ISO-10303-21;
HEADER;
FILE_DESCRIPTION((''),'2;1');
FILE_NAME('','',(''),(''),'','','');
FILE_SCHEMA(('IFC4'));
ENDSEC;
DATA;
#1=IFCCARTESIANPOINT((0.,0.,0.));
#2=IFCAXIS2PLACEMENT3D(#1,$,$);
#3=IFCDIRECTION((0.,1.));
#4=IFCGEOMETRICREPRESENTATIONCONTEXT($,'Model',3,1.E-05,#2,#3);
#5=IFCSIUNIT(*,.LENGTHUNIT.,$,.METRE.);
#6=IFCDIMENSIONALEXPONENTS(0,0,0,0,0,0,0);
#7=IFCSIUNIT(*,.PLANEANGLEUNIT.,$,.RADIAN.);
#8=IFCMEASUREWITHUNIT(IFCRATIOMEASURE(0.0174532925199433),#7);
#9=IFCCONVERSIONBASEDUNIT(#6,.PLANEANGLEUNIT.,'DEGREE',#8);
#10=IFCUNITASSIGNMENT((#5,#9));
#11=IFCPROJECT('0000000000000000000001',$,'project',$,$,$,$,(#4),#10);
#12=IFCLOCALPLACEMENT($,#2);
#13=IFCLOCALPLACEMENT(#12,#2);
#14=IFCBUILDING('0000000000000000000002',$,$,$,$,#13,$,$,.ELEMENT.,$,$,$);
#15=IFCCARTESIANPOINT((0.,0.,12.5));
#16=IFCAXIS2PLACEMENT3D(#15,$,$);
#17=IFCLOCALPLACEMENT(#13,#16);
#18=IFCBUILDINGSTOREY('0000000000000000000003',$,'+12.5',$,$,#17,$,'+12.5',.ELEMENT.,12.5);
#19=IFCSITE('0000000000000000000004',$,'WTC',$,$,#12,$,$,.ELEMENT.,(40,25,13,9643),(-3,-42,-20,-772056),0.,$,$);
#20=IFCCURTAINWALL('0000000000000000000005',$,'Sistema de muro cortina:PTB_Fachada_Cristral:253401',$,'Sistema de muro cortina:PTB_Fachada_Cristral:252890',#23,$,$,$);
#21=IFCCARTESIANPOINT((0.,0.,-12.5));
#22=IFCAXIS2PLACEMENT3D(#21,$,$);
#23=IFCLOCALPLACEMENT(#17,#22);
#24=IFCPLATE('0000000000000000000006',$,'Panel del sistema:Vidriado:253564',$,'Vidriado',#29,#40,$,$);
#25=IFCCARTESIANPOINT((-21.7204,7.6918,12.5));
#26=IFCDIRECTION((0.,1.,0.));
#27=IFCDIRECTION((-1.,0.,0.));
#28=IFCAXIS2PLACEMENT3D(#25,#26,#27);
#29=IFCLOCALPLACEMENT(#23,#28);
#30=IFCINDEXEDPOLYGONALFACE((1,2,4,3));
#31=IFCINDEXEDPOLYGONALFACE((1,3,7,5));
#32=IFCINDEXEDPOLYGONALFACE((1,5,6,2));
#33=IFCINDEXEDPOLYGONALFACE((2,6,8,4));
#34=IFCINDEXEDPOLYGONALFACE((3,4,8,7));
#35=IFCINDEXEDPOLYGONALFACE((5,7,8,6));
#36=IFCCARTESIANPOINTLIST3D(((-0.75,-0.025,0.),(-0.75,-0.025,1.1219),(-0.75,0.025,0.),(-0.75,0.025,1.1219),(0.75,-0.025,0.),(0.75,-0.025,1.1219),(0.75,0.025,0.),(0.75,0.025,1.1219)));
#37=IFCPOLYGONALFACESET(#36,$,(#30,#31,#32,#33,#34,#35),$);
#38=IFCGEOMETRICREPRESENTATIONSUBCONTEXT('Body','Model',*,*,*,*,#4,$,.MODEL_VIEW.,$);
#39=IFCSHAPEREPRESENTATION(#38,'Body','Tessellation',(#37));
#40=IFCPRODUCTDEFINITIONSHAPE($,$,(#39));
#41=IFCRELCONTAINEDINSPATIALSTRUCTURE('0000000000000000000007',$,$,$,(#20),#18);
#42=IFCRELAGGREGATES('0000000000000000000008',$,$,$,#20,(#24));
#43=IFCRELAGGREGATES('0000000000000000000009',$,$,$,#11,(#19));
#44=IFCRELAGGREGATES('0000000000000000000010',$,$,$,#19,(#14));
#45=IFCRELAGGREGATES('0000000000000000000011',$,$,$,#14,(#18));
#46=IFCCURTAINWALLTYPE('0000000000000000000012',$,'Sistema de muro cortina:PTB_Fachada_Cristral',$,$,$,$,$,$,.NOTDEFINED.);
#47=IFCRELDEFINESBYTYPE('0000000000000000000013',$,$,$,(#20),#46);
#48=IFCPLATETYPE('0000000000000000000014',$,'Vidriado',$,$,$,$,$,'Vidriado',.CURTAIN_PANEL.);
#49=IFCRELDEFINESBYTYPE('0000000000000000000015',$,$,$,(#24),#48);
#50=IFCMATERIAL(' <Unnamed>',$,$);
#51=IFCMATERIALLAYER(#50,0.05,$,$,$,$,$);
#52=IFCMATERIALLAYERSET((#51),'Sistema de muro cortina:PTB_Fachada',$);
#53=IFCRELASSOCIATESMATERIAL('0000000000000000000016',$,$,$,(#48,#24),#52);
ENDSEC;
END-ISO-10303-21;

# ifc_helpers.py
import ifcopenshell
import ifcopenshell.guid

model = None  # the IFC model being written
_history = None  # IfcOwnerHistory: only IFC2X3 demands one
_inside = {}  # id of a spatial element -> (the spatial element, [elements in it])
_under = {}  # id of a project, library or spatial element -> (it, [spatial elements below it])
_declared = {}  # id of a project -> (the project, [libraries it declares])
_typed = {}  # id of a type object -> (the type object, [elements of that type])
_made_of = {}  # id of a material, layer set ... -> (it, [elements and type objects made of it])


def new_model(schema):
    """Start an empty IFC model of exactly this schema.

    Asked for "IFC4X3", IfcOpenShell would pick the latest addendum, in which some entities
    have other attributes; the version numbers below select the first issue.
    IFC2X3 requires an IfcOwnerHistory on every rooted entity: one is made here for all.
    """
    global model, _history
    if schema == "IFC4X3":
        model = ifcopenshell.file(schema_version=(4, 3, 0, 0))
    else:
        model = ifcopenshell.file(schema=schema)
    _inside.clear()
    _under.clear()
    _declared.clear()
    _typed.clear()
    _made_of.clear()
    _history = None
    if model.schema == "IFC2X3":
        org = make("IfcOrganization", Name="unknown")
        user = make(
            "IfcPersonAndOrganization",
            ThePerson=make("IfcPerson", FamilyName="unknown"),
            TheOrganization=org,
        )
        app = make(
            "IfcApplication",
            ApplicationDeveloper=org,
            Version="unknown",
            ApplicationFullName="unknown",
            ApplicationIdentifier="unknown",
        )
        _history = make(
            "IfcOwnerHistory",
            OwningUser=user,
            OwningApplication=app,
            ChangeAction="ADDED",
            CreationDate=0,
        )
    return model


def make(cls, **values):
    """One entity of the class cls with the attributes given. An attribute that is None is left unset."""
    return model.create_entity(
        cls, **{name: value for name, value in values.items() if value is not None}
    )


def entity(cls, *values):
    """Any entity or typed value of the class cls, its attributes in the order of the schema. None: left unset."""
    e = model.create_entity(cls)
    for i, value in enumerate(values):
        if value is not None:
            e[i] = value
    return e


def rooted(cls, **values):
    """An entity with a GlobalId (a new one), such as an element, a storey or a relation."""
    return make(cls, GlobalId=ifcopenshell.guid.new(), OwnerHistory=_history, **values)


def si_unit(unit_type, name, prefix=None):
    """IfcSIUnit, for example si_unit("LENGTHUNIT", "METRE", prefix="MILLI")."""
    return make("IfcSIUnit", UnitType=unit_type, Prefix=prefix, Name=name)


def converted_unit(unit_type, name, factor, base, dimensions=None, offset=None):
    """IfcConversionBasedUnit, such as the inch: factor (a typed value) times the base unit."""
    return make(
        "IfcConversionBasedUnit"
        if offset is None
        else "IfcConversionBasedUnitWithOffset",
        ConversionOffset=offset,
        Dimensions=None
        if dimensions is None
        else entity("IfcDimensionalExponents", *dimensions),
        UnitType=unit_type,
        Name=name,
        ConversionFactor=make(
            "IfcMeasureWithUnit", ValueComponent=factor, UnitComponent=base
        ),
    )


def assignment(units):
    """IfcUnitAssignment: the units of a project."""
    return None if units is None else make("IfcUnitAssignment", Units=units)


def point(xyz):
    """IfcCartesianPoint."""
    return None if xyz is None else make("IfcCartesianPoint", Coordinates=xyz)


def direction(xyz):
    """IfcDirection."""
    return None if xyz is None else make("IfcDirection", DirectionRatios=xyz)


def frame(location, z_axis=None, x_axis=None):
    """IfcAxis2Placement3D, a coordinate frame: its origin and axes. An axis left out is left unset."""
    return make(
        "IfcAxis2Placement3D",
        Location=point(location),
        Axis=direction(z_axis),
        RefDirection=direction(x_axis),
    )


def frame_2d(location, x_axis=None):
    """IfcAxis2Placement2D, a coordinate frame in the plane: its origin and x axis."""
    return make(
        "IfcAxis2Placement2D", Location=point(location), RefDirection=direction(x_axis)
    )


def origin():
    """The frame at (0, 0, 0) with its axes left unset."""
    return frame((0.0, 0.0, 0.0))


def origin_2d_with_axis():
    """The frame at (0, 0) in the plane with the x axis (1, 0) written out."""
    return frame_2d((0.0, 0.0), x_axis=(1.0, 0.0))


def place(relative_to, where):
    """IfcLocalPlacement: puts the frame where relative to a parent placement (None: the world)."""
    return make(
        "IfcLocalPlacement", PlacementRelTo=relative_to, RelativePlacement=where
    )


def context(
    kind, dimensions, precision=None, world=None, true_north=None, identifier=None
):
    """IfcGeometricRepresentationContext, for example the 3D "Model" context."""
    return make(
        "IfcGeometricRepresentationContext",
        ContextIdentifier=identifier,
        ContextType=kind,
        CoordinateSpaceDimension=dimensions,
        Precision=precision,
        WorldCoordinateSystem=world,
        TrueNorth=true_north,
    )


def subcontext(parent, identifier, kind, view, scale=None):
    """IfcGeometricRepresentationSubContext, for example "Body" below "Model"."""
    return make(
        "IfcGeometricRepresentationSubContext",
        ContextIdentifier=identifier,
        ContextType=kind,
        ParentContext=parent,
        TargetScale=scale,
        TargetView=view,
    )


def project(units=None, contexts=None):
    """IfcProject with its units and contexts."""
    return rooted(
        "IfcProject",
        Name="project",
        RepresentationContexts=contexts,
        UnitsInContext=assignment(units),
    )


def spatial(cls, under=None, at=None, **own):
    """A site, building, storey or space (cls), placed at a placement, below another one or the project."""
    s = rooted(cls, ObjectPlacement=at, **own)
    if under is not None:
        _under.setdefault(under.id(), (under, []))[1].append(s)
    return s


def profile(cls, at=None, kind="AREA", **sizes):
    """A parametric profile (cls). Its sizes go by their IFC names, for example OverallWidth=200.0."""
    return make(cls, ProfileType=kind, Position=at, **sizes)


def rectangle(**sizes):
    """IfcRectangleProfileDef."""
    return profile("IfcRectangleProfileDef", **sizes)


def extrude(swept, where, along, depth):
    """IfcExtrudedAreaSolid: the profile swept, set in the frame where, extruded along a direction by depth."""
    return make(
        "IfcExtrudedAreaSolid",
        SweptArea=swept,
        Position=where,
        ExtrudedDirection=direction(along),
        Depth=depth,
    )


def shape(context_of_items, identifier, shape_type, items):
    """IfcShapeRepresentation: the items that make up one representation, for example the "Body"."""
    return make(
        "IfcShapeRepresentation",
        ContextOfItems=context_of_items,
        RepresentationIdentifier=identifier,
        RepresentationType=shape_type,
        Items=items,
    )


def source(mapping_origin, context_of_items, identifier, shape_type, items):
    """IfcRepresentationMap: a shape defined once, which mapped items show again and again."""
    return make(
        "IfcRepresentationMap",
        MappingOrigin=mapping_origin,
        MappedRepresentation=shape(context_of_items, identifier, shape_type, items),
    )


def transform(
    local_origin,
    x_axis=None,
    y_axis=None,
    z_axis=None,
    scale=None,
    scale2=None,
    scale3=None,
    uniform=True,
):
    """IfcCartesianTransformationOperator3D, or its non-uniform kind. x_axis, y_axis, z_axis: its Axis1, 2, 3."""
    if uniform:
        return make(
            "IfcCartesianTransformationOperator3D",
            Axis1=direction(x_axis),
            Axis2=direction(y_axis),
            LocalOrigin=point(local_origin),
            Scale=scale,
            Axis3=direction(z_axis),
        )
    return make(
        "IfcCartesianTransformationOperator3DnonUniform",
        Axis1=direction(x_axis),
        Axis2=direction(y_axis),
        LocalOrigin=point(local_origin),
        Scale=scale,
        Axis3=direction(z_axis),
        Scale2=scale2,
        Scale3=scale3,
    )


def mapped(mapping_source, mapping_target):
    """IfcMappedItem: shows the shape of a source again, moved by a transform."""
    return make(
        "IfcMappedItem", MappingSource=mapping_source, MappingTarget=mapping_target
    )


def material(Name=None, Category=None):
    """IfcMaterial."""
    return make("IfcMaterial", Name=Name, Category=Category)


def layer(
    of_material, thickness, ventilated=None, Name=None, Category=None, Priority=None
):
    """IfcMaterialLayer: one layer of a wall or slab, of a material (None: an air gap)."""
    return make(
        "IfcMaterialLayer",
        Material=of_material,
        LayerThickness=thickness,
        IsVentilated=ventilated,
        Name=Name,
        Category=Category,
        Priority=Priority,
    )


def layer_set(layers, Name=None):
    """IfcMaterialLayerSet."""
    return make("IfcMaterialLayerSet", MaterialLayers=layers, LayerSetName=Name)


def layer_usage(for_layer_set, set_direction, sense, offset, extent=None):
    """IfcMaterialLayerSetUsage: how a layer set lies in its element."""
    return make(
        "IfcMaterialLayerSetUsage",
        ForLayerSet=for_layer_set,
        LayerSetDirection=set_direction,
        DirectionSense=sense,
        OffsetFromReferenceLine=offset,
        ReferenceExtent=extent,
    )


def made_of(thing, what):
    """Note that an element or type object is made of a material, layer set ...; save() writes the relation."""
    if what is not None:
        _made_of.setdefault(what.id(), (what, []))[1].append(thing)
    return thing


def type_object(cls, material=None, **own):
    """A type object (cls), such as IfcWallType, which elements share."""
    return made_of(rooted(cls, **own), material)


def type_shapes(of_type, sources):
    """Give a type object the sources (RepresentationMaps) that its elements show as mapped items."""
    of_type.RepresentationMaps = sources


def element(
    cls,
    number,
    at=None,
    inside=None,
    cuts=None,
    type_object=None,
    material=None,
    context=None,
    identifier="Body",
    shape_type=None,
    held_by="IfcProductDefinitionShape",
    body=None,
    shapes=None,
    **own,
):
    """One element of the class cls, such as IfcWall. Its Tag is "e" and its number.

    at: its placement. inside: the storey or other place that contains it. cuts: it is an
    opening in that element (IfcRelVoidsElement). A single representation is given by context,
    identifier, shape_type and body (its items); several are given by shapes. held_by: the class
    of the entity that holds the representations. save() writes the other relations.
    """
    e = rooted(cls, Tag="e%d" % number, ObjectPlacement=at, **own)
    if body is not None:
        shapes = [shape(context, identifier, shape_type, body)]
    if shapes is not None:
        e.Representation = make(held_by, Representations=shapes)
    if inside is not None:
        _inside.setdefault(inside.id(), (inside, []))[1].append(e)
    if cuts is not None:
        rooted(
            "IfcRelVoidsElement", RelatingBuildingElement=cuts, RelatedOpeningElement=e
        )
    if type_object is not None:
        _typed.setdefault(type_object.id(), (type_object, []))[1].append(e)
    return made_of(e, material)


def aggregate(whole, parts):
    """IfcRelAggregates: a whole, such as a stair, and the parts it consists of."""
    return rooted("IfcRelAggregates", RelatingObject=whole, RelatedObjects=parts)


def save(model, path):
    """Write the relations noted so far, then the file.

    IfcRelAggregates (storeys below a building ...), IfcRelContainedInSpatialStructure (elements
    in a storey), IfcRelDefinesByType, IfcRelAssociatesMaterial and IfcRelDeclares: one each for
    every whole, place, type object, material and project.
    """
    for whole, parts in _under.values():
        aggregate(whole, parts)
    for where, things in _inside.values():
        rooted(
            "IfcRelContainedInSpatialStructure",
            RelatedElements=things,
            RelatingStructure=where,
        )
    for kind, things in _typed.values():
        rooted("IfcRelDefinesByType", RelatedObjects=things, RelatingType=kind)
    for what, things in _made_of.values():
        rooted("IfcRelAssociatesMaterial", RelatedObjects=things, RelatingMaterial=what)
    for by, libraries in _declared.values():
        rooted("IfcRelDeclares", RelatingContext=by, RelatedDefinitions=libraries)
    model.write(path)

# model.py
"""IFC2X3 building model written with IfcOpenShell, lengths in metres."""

from ifc_helpers import new_model, entity, si_unit, converted_unit, direction, frame, origin, origin_2d_with_axis, place, context, subcontext, project, spatial, rectangle, extrude, source, transform, mapped, material, layer, layer_set, layer_usage, type_object, type_shapes, element, aggregate, save


model = new_model("IFC2X3")

# Units and contexts
model_context = context("Model", 3, precision=1e-05, world=origin(), true_north=direction((0.0, 1.0)))
body_context = subcontext(model_context, "Body", "Model", "MODEL_VIEW")
ifc_project = project(units=[si_unit("LENGTHUNIT", "METRE"), converted_unit("PLANEANGLEUNIT", "DEGREE", entity("IfcRatioMeasure", 0.0174532925199433), si_unit("PLANEANGLEUNIT", "RADIAN"), dimensions=[0, 0, 0, 0, 0, 0, 0])], contexts=[model_context])

# Site, building, storey
site_placement = place(None, origin())
site = spatial("IfcSite", under=ifc_project, at=site_placement, Name="WTC", CompositionType="ELEMENT", RefLatitude=(40, 25, 13, 9643), RefLongitude=(-3, -42, -20, -772056), RefElevation=0.0)
building_placement = place(site_placement, origin())
building = spatial("IfcBuilding", under=site, at=building_placement, CompositionType="ELEMENT")
storey_placement = place(building_placement, frame((0.0, 0.0, 12.5)))
storey = spatial("IfcBuildingStorey", under=building, at=storey_placement, Name="+12.5", LongName="+12.5", CompositionType="ELEMENT", Elevation=12.5)

# Curtain wall, plate
curtain_wall_type = type_object("IfcCurtainWallType", Name="Sistema de muro cortina:PTB_Fachada_Cristral", PredefinedType="NOTDEFINED")
curtain_wall_placement = place(storey_placement, frame((0.0, 0.0, -12.5)))
curtain_wall = element("IfcCurtainWall", 1, at=curtain_wall_placement, inside=storey, type_object=curtain_wall_type, Name="Sistema de muro cortina:PTB_Fachada_Cristral:253401", ObjectType="Sistema de muro cortina:PTB_Fachada_Cristral:252890")
ifc_material = material(Name=" <Unnamed>")
ifc_layer = layer(ifc_material, 0.05)
ifc_layer_set = layer_set([ifc_layer], Name="Sistema de muro cortina:PTB_Fachada")
plate_type_1 = type_object("IfcPlateType", Name="Vidriado", ElementType="Vidriado", PredefinedType="CURTAIN_PANEL", material=ifc_layer_set)
shared_shape_1 = source(origin(), body_context, "Body", "SweptSolid", [
    extrude(rectangle(XDim=0.05, YDim=1.5, at=origin_2d_with_axis()), frame((0.0, 0.0, 0.0), z_axis=(0.0, 0.0, 1.0), x_axis=(0.0, 1.0, 0.0)), (0.0, 0.0, 1.0), 1.1219),
])
type_shapes(plate_type_1, [shared_shape_1])
ifc_layer_usage_1 = layer_usage(ifc_layer_set, "AXIS3", "POSITIVE", 0.0)
plate_1_placement = place(curtain_wall_placement, frame((-21.7204, 7.6918, 12.5), z_axis=(0.0, 1.0, 0.0), x_axis=(-1.0, 0.0, 0.0)))
plate_1 = element("IfcPlate", 2, at=plate_1_placement, type_object=plate_type_1, material=ifc_layer_usage_1, Name="Panel del sistema:Vidriado:253564", ObjectType="Vidriado", context=body_context, shape_type="MappedRepresentation", body=[
    mapped(shared_shape_1, transform((0.0, 0.0, 0.0), scale=1.0)),
])
aggregate(curtain_wall, [plate_1])

save(model, "model.ifc")
